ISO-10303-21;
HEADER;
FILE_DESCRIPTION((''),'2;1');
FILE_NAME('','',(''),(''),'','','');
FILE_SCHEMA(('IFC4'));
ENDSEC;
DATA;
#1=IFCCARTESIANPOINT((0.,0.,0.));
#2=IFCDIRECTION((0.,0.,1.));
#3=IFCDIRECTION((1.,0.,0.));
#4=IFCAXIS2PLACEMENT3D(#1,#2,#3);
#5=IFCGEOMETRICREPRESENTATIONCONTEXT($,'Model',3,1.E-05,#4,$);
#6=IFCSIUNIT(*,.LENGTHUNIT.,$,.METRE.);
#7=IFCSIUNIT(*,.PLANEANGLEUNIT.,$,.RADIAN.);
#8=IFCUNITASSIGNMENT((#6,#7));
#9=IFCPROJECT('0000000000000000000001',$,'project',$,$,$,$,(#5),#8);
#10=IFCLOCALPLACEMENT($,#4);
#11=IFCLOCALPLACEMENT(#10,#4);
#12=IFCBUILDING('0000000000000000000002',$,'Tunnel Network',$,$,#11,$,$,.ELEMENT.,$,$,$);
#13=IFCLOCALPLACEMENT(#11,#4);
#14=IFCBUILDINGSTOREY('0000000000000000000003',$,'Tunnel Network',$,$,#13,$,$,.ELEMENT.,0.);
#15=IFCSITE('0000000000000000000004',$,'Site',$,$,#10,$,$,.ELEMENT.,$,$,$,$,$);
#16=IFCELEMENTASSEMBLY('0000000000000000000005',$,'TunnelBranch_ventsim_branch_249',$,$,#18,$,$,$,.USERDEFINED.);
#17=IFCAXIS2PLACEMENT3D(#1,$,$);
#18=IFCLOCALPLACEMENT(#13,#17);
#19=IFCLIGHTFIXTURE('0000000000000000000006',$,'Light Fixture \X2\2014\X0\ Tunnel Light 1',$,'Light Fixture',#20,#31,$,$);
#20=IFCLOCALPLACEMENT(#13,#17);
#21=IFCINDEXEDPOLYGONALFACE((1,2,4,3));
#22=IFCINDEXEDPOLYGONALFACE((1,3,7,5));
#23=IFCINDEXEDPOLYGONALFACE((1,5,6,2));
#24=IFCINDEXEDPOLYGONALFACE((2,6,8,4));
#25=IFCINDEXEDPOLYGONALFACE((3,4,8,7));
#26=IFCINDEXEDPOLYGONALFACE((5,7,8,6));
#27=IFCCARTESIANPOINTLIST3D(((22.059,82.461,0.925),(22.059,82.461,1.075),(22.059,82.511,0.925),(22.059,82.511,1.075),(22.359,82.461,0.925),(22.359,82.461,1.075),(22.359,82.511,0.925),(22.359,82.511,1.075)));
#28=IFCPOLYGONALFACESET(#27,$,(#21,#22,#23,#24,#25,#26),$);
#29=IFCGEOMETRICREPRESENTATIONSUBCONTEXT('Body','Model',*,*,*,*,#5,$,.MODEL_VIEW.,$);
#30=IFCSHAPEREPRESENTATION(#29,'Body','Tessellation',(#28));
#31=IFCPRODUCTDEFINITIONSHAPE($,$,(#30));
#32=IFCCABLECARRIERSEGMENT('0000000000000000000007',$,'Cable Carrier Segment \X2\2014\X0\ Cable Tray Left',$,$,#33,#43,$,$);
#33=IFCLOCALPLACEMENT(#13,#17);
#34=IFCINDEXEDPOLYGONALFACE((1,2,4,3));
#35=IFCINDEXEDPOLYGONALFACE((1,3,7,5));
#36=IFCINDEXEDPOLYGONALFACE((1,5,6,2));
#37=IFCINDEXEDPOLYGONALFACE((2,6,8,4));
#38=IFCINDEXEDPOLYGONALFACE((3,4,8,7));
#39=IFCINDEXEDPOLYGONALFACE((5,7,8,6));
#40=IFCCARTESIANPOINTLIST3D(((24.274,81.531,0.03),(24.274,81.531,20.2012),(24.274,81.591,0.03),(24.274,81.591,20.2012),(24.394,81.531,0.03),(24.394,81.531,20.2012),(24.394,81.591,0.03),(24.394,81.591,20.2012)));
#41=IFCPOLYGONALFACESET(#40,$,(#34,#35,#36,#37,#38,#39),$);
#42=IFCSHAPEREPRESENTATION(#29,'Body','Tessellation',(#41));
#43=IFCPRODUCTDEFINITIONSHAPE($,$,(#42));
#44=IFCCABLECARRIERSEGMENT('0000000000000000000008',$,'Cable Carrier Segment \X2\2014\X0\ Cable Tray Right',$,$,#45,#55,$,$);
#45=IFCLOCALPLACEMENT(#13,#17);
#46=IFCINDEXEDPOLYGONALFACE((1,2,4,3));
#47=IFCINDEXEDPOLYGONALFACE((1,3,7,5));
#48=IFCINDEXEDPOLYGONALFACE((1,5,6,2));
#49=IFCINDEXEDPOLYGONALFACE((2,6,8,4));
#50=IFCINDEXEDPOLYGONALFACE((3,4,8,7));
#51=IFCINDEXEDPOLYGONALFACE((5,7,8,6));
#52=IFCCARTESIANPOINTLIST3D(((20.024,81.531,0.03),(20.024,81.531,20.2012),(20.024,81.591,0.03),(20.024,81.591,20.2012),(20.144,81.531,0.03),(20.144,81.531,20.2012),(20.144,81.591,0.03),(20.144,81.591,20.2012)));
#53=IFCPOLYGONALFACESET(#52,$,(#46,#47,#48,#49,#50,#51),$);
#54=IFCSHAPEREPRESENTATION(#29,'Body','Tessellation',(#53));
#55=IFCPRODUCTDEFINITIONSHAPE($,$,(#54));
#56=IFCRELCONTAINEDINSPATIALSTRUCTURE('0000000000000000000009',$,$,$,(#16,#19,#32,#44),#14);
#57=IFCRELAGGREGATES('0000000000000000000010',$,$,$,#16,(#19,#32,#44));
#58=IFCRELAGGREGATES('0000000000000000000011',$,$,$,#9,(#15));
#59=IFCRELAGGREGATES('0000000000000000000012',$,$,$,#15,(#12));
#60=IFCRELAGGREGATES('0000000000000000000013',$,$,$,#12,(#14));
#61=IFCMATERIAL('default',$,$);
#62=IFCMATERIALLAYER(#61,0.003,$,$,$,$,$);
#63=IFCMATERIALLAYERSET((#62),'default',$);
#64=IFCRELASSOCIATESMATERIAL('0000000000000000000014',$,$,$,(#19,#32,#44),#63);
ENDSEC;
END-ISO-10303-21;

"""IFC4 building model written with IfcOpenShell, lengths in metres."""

from ifc_helpers import new_model, si_unit, frame, origin_with_axes, origin_2d_with_axis, place, context, subcontext, project, spatial, rectangle, extrude, material, layer, layer_set, layer_usage, element, aggregate, save


model = new_model("IFC4")

# Units and contexts
model_context = context("Model", 3, precision=1e-05, world=origin_with_axes())
body_context = subcontext(model_context, "Body", "Model", "MODEL_VIEW")
ifc_project = project(units=[si_unit("LENGTHUNIT", "METRE"), si_unit("PLANEANGLEUNIT", "RADIAN")], contexts=[model_context])

# Site, building, storey
site_placement = place(None, origin_with_axes())
site = spatial("IfcSite", under=ifc_project, at=site_placement, Name="Site", CompositionType="ELEMENT")
building_placement = place(site_placement, origin_with_axes())
building = spatial("IfcBuilding", under=site, at=building_placement, Name="Tunnel Network", CompositionType="ELEMENT")
storey_placement = place(building_placement, origin_with_axes())
storey = spatial("IfcBuildingStorey", under=building, at=storey_placement, Name="Tunnel Network", CompositionType="ELEMENT", Elevation=0.0)

# Element assembly
ifc_material_1 = material(Name="default")
ifc_layer_1 = layer(ifc_material_1, 0.003)
ifc_layer_set_1 = layer_set([ifc_layer_1], Name="default")
assembly_1_placement = place(storey_placement, frame((22.209, 82.461, 1.0), z_axis=(0.0, 1.0, 0.0), x_axis=(-1.0, 0.0, 0.0)))
assembly_1 = element("IfcElementAssembly", 1, at=assembly_1_placement, inside=storey, Name="TunnelBranch_ventsim_branch_249", PredefinedType="USERDEFINED")

# Light fixture
ifc_layer_usage_1 = layer_usage(ifc_layer_set_1, "AXIS2", "POSITIVE", 0.0)
light_fixture_1_placement = place(storey_placement, frame((22.209, 82.461, 1.0), z_axis=(0.0, 1.0, 0.0), x_axis=(-1.0, 0.0, 0.0)))
light_fixture_1 = element("IfcLightFixture", 2, at=light_fixture_1_placement, inside=storey, material=ifc_layer_usage_1, Name="Light Fixture — Tunnel Light 1", ObjectType="Light Fixture", context=body_context, shape_type="SweptSolid", body=[
    extrude(rectangle(XDim=0.3, YDim=0.15, at=origin_2d_with_axis()), origin_with_axes(), (0.0, 0.0, 1.0), 0.05),
])

# Cable carrier segments
ifc_layer_usage_2 = layer_usage(ifc_layer_set_1, "AXIS2", "POSITIVE", 0.0)
cable_carrier_segment_1_placement = place(storey_placement, frame((24.334, 81.561, 0.03), z_axis=(0.0, 0.0, 1.0), x_axis=(-1.0, 0.0, 0.0)))
cable_carrier_segment_1 = element("IfcCableCarrierSegment", 3, at=cable_carrier_segment_1_placement, inside=storey, material=ifc_layer_usage_2, Name="Cable Carrier Segment — Cable Tray Left", context=body_context, shape_type="SweptSolid", body=[
    extrude(rectangle(XDim=0.12, YDim=0.06, at=origin_2d_with_axis()), origin_with_axes(), (0.0, 0.0, 1.0), 20.1712),
])
ifc_layer_usage_3 = layer_usage(ifc_layer_set_1, "AXIS2", "POSITIVE", 0.0)
cable_carrier_segment_2_placement = place(storey_placement, frame((20.084, 81.561, 0.03), z_axis=(0.0, 0.0, 1.0), x_axis=(-1.0, 0.0, 0.0)))
cable_carrier_segment_2 = element("IfcCableCarrierSegment", 4, at=cable_carrier_segment_2_placement, inside=storey, material=ifc_layer_usage_3, Name="Cable Carrier Segment — Cable Tray Right", context=body_context, shape_type="SweptSolid", body=[
    extrude(rectangle(XDim=0.12, YDim=0.06, at=origin_2d_with_axis()), origin_with_axes(), (0.0, 0.0, 1.0), 20.1712),
])
aggregate(assembly_1, [light_fixture_1, cable_carrier_segment_1, cable_carrier_segment_2])

save(model, "model.ifc")
